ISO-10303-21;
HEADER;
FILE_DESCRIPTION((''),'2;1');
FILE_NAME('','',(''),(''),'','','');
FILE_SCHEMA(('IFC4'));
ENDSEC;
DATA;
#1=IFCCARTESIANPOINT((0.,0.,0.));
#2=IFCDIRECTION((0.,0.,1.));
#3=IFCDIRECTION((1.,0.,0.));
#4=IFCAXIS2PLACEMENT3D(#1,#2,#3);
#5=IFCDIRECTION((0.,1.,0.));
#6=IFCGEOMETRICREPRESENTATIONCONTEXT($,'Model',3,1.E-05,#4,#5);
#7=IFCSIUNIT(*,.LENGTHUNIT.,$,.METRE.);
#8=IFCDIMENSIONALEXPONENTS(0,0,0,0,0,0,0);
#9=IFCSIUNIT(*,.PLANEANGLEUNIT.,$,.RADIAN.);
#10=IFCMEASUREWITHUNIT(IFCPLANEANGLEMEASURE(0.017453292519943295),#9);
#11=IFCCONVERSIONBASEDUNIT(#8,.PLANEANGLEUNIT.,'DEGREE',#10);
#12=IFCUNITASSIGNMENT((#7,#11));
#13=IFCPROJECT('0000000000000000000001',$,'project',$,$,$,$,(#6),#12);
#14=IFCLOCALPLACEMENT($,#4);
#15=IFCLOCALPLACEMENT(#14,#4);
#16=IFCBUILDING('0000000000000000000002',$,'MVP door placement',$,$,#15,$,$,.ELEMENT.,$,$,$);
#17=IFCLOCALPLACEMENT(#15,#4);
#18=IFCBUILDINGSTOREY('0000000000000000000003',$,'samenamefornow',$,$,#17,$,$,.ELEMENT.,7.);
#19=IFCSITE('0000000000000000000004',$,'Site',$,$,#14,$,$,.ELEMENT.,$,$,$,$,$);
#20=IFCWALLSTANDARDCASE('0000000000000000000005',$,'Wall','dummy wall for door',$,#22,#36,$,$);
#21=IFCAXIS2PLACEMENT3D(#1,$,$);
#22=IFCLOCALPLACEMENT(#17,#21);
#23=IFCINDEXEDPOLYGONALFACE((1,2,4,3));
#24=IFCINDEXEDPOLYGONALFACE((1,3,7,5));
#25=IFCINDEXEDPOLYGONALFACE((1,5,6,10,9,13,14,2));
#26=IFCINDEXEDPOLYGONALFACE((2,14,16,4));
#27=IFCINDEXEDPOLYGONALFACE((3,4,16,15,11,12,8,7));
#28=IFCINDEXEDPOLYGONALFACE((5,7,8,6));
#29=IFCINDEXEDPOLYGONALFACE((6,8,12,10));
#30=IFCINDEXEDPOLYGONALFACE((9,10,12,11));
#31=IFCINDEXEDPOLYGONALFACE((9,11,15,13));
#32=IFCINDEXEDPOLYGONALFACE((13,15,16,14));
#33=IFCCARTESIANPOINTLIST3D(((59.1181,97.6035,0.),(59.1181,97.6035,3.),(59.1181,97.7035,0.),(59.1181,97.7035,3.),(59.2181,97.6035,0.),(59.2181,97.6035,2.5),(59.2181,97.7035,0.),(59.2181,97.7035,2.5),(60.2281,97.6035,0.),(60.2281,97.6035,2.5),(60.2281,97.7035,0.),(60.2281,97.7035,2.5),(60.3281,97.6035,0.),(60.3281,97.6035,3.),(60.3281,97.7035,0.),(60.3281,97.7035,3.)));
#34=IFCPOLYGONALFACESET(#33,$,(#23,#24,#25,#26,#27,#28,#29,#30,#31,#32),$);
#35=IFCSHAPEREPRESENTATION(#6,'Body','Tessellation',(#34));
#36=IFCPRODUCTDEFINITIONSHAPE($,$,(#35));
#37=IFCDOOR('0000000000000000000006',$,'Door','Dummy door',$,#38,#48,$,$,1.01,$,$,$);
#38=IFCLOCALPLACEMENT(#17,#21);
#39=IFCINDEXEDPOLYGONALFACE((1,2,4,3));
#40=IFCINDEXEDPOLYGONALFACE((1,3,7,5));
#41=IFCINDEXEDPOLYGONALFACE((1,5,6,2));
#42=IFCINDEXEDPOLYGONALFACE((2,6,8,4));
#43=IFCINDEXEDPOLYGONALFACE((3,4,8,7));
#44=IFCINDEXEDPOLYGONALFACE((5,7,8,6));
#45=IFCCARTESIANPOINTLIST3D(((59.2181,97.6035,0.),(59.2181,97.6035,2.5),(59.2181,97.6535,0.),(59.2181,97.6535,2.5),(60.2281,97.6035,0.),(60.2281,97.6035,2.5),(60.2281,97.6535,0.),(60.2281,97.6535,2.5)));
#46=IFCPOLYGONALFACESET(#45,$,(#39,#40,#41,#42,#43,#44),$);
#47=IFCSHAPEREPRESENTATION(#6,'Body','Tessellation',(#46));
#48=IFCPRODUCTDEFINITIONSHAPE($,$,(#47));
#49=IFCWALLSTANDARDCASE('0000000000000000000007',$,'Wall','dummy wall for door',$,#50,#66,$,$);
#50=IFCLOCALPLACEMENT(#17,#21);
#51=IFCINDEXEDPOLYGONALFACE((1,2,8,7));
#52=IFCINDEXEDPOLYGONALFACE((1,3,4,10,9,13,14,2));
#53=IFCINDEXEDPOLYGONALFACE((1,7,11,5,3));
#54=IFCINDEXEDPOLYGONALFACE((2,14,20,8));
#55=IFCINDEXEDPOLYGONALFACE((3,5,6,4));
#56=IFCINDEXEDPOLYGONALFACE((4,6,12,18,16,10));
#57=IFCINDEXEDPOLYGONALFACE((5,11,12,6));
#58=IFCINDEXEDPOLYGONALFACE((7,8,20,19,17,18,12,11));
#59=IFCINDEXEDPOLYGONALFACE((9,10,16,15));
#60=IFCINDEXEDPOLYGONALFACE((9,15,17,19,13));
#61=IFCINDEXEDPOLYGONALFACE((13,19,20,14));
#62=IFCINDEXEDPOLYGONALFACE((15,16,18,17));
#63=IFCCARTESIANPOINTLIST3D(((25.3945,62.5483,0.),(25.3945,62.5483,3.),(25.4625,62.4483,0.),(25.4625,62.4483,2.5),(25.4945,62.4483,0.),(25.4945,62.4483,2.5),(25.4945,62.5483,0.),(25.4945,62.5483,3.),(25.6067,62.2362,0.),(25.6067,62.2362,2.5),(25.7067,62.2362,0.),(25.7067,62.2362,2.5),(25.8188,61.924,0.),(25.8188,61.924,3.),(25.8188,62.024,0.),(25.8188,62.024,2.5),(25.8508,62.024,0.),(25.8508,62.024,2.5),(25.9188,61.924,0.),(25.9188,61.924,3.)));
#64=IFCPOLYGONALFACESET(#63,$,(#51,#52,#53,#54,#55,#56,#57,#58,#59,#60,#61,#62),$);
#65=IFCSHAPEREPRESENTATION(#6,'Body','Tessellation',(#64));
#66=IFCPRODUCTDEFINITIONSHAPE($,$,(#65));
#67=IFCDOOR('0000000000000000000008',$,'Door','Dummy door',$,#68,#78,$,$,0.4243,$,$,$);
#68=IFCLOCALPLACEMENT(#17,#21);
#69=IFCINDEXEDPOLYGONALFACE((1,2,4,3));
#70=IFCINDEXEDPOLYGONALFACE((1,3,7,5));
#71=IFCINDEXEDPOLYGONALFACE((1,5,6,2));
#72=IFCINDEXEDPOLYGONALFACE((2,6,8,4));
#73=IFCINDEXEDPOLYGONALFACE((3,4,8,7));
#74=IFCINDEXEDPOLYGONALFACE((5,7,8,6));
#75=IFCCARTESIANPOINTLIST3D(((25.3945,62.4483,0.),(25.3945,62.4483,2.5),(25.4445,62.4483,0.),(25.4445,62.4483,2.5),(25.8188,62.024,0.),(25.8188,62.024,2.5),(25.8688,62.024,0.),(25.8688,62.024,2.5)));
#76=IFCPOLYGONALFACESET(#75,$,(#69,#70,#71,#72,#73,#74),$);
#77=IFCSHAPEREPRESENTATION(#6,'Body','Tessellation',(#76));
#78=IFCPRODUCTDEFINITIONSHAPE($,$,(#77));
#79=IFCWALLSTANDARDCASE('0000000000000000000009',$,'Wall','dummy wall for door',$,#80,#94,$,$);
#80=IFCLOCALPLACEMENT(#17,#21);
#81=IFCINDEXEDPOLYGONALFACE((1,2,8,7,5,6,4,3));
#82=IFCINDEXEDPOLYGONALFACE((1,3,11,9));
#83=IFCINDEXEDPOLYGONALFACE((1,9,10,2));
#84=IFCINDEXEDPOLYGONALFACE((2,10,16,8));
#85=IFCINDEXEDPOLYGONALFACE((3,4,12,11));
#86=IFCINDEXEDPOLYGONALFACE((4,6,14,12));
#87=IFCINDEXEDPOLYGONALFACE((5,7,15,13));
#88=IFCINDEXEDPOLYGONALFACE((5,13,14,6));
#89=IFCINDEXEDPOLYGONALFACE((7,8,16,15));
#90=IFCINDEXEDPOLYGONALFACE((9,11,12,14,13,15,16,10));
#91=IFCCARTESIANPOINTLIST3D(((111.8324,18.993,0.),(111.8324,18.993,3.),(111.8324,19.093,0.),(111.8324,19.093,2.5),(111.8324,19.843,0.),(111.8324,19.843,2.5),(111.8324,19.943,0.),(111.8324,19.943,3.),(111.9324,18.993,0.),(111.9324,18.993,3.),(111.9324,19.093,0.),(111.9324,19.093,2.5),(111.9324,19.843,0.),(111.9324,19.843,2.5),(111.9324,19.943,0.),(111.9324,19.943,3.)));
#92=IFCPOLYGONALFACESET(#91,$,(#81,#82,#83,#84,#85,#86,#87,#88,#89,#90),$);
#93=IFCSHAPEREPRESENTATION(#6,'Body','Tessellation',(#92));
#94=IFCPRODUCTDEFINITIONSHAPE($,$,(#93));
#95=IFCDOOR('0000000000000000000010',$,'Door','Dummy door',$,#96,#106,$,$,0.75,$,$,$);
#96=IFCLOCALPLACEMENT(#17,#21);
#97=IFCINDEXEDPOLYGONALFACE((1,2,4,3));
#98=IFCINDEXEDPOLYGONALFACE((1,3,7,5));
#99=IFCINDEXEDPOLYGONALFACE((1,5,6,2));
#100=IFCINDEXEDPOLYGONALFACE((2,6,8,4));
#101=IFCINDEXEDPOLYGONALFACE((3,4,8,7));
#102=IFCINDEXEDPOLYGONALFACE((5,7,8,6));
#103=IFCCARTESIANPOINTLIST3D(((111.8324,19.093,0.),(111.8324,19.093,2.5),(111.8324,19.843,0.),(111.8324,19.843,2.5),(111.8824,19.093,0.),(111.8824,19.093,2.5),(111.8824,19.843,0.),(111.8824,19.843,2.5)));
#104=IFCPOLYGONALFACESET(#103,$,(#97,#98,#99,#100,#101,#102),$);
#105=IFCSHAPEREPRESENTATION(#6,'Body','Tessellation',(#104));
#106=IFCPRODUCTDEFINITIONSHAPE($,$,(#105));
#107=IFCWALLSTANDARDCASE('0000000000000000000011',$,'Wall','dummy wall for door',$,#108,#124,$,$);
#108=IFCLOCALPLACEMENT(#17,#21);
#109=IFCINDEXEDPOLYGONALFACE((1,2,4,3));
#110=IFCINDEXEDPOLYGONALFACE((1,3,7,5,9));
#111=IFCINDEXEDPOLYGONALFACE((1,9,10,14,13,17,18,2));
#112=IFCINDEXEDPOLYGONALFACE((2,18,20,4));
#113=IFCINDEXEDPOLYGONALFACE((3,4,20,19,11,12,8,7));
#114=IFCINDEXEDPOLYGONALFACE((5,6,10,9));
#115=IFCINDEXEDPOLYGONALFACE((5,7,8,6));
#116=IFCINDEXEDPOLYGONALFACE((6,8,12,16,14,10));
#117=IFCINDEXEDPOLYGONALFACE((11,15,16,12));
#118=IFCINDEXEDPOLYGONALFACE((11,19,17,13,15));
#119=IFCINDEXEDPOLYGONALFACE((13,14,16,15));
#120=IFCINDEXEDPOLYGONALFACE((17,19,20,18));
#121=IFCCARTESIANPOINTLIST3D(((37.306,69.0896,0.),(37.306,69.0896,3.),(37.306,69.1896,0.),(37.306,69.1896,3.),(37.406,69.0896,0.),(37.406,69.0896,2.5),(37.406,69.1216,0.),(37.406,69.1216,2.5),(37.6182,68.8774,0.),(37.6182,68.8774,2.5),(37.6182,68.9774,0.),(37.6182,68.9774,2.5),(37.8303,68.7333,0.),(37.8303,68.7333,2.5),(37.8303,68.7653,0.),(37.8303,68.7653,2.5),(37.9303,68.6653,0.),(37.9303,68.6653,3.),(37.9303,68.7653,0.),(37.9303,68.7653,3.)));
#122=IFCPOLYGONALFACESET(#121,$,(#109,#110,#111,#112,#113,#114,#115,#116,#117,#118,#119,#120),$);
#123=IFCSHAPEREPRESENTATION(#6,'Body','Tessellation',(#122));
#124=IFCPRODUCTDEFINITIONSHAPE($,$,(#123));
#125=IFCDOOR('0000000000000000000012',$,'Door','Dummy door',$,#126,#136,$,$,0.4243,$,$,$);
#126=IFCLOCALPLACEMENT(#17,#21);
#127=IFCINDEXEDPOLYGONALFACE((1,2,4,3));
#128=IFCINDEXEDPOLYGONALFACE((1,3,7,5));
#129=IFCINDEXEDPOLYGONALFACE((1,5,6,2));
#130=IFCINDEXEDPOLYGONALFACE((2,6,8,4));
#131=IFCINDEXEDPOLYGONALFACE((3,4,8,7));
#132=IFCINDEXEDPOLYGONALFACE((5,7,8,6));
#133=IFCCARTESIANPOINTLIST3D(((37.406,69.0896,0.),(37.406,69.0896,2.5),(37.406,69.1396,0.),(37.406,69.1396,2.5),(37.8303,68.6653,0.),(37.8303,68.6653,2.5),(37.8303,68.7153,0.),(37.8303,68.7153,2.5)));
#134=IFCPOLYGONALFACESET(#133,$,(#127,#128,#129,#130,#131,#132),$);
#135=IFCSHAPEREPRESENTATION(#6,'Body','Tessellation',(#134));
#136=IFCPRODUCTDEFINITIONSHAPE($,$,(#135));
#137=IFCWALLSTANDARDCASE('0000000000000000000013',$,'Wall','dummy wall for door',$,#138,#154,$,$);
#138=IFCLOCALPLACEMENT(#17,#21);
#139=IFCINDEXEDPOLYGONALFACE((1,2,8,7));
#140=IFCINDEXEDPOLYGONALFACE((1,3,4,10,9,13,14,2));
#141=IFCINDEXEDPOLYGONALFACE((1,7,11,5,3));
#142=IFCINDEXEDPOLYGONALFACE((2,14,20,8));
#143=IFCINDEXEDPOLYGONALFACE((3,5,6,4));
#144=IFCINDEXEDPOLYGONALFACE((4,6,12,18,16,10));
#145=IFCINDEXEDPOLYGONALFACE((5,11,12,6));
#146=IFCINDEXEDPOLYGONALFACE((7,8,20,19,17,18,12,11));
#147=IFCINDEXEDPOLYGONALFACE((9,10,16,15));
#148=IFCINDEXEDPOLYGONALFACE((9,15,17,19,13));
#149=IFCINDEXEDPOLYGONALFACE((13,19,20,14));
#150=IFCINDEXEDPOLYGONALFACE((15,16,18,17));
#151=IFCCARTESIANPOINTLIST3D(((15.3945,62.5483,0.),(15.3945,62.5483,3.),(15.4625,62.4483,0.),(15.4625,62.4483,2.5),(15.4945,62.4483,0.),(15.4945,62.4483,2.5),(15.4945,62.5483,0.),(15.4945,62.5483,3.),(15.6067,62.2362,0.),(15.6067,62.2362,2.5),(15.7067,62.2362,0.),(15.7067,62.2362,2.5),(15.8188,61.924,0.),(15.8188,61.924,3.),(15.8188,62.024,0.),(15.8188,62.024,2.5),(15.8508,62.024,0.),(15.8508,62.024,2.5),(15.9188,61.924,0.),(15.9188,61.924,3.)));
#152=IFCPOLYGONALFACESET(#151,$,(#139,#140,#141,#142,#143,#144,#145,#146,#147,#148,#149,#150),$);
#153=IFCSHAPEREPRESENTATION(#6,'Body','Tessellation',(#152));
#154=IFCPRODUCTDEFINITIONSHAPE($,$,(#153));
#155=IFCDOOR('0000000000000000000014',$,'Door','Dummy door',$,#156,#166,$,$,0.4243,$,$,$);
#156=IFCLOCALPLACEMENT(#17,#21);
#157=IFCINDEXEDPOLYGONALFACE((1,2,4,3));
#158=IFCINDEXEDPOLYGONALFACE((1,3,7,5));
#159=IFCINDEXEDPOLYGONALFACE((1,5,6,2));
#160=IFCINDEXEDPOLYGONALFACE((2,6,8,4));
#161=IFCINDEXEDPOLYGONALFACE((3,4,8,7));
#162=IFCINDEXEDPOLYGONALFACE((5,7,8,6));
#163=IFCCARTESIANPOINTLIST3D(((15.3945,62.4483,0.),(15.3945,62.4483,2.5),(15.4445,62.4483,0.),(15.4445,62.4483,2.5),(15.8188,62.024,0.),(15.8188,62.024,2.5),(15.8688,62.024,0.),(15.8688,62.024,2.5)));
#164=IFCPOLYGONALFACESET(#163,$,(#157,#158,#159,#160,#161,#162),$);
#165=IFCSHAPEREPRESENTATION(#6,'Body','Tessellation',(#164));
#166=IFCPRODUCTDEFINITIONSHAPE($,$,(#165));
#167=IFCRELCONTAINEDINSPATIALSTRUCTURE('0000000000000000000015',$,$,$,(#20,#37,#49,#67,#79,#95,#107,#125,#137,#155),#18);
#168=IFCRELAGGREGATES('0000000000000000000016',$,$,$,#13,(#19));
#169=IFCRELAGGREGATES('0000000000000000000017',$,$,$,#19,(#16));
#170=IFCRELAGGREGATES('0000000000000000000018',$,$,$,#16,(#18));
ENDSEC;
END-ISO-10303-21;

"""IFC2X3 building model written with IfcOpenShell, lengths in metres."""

from ifc_helpers import new_model, entity, si_unit, converted_unit, direction, origin_with_axes, place, context, project, spatial, polyline, outline, extrude, element, fill, save


model = new_model("IFC2X3")

# Units and contexts
model_context = context("Model", 3, precision=1e-05, world=origin_with_axes(), true_north=direction((0.0, 1.0, 0.0)))
ifc_project = project(units=[si_unit("LENGTHUNIT", "METRE"), converted_unit("PLANEANGLEUNIT", "DEGREE", entity("IfcPlaneAngleMeasure", 0.017453292519943295), si_unit("PLANEANGLEUNIT", "RADIAN"), dimensions=[0, 0, 0, 0, 0, 0, 0])], contexts=[model_context])

# Site, building, storey
site_placement = place(None, origin_with_axes())
site = spatial("IfcSite", under=ifc_project, at=site_placement, Name="Site", CompositionType="ELEMENT")
building_placement = place(site_placement, origin_with_axes())
building = spatial("IfcBuilding", under=site, at=building_placement, Name="MVP door placement", CompositionType="ELEMENT")
storey_placement = place(building_placement, origin_with_axes())
storey = spatial("IfcBuildingStorey", under=building, at=storey_placement, Name="samenamefornow", CompositionType="ELEMENT", Elevation=7.0)

# Walls, openings, doors
wall_1_placement = place(storey_placement, origin_with_axes())
wall_1 = element("IfcWallStandardCase", 1, at=wall_1_placement, inside=storey, Name="Wall", Description="dummy wall for door", context=model_context, shape_type="SweptSolid", body=[
    extrude(outline(polyline([(60.3281, 97.6035, 0.0), (59.1181, 97.6035, 0.0), (59.1181, 97.7035, 0.0), (60.3281, 97.7035, 0.0), (60.3281, 97.6035, 0.0)])), origin_with_axes(), (0.0, 0.0, 1.0), 3.0),
])
opening_1_placement = place(wall_1_placement, origin_with_axes())
opening_1 = element("IfcOpeningElement", 2, at=opening_1_placement, cuts=wall_1, context=model_context, shape_type="SweptSolid", body=[
    extrude(outline(polyline([(60.2281, 97.6035, 0.0), (59.2181, 97.6035, 0.0), (59.2181, 97.7035, 0.0), (60.2281, 97.7035, 0.0), (60.2281, 97.6035, 0.0)])), origin_with_axes(), (0.0, 0.0, 1.0), 2.5),
])
door_1_placement = place(opening_1_placement, origin_with_axes())
door_1 = element("IfcDoor", 3, at=door_1_placement, inside=storey, Name="Door", Description="Dummy door", OverallWidth=1.01, context=model_context, shape_type="SweptSolid", body=[
    extrude(outline(polyline([(60.2281, 97.6035, 0.0), (59.2181, 97.6035, 0.0), (59.2181, 97.6535, 0.0), (60.2281, 97.6535, 0.0), (60.2281, 97.6035, 0.0)])), origin_with_axes(), (0.0, 0.0, 1.0), 2.5),
])
fill(opening_1, door_1)
wall_2_placement = place(storey_placement, origin_with_axes())
wall_2 = element("IfcWallStandardCase", 4, at=wall_2_placement, inside=storey, Name="Wall", Description="dummy wall for door", context=model_context, shape_type="SweptSolid", body=[
    extrude(outline(polyline([(25.8188, 61.924, 0.0), (25.3945, 62.5483, 0.0), (25.4945, 62.5483, 0.0), (25.9188, 61.924, 0.0), (25.8188, 61.924, 0.0)])), origin_with_axes(), (0.0, 0.0, 1.0), 3.0),
])
opening_2_placement = place(wall_2_placement, origin_with_axes())
opening_2 = element("IfcOpeningElement", 5, at=opening_2_placement, cuts=wall_2, context=model_context, shape_type="SweptSolid", body=[
    extrude(outline(polyline([(25.8188, 62.024, 0.0), (25.3945, 62.4483, 0.0), (25.4945, 62.4483, 0.0), (25.9188, 62.024, 0.0), (25.8188, 62.024, 0.0)])), origin_with_axes(), (0.0, 0.0, 1.0), 2.5),
])
door_2_placement = place(opening_2_placement, origin_with_axes())
door_2 = element("IfcDoor", 6, at=door_2_placement, inside=storey, Name="Door", Description="Dummy door", OverallWidth=0.4243, context=model_context, shape_type="SweptSolid", body=[
    extrude(outline(polyline([(25.8188, 62.024, 0.0), (25.3945, 62.4483, 0.0), (25.4445, 62.4483, 0.0), (25.8688, 62.024, 0.0), (25.8188, 62.024, 0.0)])), origin_with_axes(), (0.0, 0.0, 1.0), 2.5),
])
fill(opening_2, door_2)
wall_3_placement = place(storey_placement, origin_with_axes())
wall_3 = element("IfcWallStandardCase", 7, at=wall_3_placement, inside=storey, Name="Wall", Description="dummy wall for door", context=model_context, shape_type="SweptSolid", body=[
    extrude(outline(polyline([(111.8324, 18.993, 0.0), (111.8324, 19.943, 0.0), (111.9324, 19.943, 0.0), (111.9324, 18.993, 0.0), (111.8324, 18.993, 0.0)])), origin_with_axes(), (0.0, 0.0, 1.0), 3.0),
])
opening_3_placement = place(wall_3_placement, origin_with_axes())
opening_3 = element("IfcOpeningElement", 8, at=opening_3_placement, cuts=wall_3, context=model_context, shape_type="SweptSolid", body=[
    extrude(outline(polyline([(111.8324, 19.093, 0.0), (111.8324, 19.843, 0.0), (111.9324, 19.843, 0.0), (111.9324, 19.093, 0.0), (111.8324, 19.093, 0.0)])), origin_with_axes(), (0.0, 0.0, 1.0), 2.5),
])
door_3_placement = place(opening_3_placement, origin_with_axes())
door_3 = element("IfcDoor", 9, at=door_3_placement, inside=storey, Name="Door", Description="Dummy door", OverallWidth=0.75, context=model_context, shape_type="SweptSolid", body=[
    extrude(outline(polyline([(111.8324, 19.093, 0.0), (111.8324, 19.843, 0.0), (111.8824, 19.843, 0.0), (111.8824, 19.093, 0.0), (111.8324, 19.093, 0.0)])), origin_with_axes(), (0.0, 0.0, 1.0), 2.5),
])
fill(opening_3, door_3)
wall_4_placement = place(storey_placement, origin_with_axes())
wall_4 = element("IfcWallStandardCase", 10, at=wall_4_placement, inside=storey, Name="Wall", Description="dummy wall for door", context=model_context, shape_type="SweptSolid", body=[
    extrude(outline(polyline([(37.306, 69.0896, 0.0), (37.9303, 68.6653, 0.0), (37.9303, 68.7653, 0.0), (37.306, 69.1896, 0.0), (37.306, 69.0896, 0.0)])), origin_with_axes(), (0.0, 0.0, 1.0), 3.0),
])
opening_4_placement = place(wall_4_placement, origin_with_axes())
opening_4 = element("IfcOpeningElement", 11, at=opening_4_placement, cuts=wall_4, context=model_context, shape_type="SweptSolid", body=[
    extrude(outline(polyline([(37.406, 69.0896, 0.0), (37.8303, 68.6653, 0.0), (37.8303, 68.7653, 0.0), (37.406, 69.1896, 0.0), (37.406, 69.0896, 0.0)])), origin_with_axes(), (0.0, 0.0, 1.0), 2.5),
])
door_4_placement = place(opening_4_placement, origin_with_axes())
door_4 = element("IfcDoor", 12, at=door_4_placement, inside=storey, Name="Door", Description="Dummy door", OverallWidth=0.4243, context=model_context, shape_type="SweptSolid", body=[
    extrude(outline(polyline([(37.406, 69.0896, 0.0), (37.8303, 68.6653, 0.0), (37.8303, 68.7153, 0.0), (37.406, 69.1396, 0.0), (37.406, 69.0896, 0.0)])), origin_with_axes(), (0.0, 0.0, 1.0), 2.5),
])
fill(opening_4, door_4)
wall_5_placement = place(storey_placement, origin_with_axes())
wall_5 = element("IfcWallStandardCase", 13, at=wall_5_placement, inside=storey, Name="Wall", Description="dummy wall for door", context=model_context, shape_type="SweptSolid", body=[
    extrude(outline(polyline([(15.8188, 61.924, 0.0), (15.3945, 62.5483, 0.0), (15.4945, 62.5483, 0.0), (15.9188, 61.924, 0.0), (15.8188, 61.924, 0.0)])), origin_with_axes(), (0.0, 0.0, 1.0), 3.0),
])
opening_5_placement = place(wall_5_placement, origin_with_axes())
opening_5 = element("IfcOpeningElement", 14, at=opening_5_placement, cuts=wall_5, context=model_context, shape_type="SweptSolid", body=[
    extrude(outline(polyline([(15.8188, 62.024, 0.0), (15.3945, 62.4483, 0.0), (15.4945, 62.4483, 0.0), (15.9188, 62.024, 0.0), (15.8188, 62.024, 0.0)])), origin_with_axes(), (0.0, 0.0, 1.0), 2.5),
])
door_5_placement = place(opening_5_placement, origin_with_axes())
door_5 = element("IfcDoor", 15, at=door_5_placement, inside=storey, Name="Door", Description="Dummy door", OverallWidth=0.4243, context=model_context, shape_type="SweptSolid", body=[
    extrude(outline(polyline([(15.8188, 62.024, 0.0), (15.3945, 62.4483, 0.0), (15.4445, 62.4483, 0.0), (15.8688, 62.024, 0.0), (15.8188, 62.024, 0.0)])), origin_with_axes(), (0.0, 0.0, 1.0), 2.5),
])
fill(opening_5, door_5)

save(model, "model.ifc")
